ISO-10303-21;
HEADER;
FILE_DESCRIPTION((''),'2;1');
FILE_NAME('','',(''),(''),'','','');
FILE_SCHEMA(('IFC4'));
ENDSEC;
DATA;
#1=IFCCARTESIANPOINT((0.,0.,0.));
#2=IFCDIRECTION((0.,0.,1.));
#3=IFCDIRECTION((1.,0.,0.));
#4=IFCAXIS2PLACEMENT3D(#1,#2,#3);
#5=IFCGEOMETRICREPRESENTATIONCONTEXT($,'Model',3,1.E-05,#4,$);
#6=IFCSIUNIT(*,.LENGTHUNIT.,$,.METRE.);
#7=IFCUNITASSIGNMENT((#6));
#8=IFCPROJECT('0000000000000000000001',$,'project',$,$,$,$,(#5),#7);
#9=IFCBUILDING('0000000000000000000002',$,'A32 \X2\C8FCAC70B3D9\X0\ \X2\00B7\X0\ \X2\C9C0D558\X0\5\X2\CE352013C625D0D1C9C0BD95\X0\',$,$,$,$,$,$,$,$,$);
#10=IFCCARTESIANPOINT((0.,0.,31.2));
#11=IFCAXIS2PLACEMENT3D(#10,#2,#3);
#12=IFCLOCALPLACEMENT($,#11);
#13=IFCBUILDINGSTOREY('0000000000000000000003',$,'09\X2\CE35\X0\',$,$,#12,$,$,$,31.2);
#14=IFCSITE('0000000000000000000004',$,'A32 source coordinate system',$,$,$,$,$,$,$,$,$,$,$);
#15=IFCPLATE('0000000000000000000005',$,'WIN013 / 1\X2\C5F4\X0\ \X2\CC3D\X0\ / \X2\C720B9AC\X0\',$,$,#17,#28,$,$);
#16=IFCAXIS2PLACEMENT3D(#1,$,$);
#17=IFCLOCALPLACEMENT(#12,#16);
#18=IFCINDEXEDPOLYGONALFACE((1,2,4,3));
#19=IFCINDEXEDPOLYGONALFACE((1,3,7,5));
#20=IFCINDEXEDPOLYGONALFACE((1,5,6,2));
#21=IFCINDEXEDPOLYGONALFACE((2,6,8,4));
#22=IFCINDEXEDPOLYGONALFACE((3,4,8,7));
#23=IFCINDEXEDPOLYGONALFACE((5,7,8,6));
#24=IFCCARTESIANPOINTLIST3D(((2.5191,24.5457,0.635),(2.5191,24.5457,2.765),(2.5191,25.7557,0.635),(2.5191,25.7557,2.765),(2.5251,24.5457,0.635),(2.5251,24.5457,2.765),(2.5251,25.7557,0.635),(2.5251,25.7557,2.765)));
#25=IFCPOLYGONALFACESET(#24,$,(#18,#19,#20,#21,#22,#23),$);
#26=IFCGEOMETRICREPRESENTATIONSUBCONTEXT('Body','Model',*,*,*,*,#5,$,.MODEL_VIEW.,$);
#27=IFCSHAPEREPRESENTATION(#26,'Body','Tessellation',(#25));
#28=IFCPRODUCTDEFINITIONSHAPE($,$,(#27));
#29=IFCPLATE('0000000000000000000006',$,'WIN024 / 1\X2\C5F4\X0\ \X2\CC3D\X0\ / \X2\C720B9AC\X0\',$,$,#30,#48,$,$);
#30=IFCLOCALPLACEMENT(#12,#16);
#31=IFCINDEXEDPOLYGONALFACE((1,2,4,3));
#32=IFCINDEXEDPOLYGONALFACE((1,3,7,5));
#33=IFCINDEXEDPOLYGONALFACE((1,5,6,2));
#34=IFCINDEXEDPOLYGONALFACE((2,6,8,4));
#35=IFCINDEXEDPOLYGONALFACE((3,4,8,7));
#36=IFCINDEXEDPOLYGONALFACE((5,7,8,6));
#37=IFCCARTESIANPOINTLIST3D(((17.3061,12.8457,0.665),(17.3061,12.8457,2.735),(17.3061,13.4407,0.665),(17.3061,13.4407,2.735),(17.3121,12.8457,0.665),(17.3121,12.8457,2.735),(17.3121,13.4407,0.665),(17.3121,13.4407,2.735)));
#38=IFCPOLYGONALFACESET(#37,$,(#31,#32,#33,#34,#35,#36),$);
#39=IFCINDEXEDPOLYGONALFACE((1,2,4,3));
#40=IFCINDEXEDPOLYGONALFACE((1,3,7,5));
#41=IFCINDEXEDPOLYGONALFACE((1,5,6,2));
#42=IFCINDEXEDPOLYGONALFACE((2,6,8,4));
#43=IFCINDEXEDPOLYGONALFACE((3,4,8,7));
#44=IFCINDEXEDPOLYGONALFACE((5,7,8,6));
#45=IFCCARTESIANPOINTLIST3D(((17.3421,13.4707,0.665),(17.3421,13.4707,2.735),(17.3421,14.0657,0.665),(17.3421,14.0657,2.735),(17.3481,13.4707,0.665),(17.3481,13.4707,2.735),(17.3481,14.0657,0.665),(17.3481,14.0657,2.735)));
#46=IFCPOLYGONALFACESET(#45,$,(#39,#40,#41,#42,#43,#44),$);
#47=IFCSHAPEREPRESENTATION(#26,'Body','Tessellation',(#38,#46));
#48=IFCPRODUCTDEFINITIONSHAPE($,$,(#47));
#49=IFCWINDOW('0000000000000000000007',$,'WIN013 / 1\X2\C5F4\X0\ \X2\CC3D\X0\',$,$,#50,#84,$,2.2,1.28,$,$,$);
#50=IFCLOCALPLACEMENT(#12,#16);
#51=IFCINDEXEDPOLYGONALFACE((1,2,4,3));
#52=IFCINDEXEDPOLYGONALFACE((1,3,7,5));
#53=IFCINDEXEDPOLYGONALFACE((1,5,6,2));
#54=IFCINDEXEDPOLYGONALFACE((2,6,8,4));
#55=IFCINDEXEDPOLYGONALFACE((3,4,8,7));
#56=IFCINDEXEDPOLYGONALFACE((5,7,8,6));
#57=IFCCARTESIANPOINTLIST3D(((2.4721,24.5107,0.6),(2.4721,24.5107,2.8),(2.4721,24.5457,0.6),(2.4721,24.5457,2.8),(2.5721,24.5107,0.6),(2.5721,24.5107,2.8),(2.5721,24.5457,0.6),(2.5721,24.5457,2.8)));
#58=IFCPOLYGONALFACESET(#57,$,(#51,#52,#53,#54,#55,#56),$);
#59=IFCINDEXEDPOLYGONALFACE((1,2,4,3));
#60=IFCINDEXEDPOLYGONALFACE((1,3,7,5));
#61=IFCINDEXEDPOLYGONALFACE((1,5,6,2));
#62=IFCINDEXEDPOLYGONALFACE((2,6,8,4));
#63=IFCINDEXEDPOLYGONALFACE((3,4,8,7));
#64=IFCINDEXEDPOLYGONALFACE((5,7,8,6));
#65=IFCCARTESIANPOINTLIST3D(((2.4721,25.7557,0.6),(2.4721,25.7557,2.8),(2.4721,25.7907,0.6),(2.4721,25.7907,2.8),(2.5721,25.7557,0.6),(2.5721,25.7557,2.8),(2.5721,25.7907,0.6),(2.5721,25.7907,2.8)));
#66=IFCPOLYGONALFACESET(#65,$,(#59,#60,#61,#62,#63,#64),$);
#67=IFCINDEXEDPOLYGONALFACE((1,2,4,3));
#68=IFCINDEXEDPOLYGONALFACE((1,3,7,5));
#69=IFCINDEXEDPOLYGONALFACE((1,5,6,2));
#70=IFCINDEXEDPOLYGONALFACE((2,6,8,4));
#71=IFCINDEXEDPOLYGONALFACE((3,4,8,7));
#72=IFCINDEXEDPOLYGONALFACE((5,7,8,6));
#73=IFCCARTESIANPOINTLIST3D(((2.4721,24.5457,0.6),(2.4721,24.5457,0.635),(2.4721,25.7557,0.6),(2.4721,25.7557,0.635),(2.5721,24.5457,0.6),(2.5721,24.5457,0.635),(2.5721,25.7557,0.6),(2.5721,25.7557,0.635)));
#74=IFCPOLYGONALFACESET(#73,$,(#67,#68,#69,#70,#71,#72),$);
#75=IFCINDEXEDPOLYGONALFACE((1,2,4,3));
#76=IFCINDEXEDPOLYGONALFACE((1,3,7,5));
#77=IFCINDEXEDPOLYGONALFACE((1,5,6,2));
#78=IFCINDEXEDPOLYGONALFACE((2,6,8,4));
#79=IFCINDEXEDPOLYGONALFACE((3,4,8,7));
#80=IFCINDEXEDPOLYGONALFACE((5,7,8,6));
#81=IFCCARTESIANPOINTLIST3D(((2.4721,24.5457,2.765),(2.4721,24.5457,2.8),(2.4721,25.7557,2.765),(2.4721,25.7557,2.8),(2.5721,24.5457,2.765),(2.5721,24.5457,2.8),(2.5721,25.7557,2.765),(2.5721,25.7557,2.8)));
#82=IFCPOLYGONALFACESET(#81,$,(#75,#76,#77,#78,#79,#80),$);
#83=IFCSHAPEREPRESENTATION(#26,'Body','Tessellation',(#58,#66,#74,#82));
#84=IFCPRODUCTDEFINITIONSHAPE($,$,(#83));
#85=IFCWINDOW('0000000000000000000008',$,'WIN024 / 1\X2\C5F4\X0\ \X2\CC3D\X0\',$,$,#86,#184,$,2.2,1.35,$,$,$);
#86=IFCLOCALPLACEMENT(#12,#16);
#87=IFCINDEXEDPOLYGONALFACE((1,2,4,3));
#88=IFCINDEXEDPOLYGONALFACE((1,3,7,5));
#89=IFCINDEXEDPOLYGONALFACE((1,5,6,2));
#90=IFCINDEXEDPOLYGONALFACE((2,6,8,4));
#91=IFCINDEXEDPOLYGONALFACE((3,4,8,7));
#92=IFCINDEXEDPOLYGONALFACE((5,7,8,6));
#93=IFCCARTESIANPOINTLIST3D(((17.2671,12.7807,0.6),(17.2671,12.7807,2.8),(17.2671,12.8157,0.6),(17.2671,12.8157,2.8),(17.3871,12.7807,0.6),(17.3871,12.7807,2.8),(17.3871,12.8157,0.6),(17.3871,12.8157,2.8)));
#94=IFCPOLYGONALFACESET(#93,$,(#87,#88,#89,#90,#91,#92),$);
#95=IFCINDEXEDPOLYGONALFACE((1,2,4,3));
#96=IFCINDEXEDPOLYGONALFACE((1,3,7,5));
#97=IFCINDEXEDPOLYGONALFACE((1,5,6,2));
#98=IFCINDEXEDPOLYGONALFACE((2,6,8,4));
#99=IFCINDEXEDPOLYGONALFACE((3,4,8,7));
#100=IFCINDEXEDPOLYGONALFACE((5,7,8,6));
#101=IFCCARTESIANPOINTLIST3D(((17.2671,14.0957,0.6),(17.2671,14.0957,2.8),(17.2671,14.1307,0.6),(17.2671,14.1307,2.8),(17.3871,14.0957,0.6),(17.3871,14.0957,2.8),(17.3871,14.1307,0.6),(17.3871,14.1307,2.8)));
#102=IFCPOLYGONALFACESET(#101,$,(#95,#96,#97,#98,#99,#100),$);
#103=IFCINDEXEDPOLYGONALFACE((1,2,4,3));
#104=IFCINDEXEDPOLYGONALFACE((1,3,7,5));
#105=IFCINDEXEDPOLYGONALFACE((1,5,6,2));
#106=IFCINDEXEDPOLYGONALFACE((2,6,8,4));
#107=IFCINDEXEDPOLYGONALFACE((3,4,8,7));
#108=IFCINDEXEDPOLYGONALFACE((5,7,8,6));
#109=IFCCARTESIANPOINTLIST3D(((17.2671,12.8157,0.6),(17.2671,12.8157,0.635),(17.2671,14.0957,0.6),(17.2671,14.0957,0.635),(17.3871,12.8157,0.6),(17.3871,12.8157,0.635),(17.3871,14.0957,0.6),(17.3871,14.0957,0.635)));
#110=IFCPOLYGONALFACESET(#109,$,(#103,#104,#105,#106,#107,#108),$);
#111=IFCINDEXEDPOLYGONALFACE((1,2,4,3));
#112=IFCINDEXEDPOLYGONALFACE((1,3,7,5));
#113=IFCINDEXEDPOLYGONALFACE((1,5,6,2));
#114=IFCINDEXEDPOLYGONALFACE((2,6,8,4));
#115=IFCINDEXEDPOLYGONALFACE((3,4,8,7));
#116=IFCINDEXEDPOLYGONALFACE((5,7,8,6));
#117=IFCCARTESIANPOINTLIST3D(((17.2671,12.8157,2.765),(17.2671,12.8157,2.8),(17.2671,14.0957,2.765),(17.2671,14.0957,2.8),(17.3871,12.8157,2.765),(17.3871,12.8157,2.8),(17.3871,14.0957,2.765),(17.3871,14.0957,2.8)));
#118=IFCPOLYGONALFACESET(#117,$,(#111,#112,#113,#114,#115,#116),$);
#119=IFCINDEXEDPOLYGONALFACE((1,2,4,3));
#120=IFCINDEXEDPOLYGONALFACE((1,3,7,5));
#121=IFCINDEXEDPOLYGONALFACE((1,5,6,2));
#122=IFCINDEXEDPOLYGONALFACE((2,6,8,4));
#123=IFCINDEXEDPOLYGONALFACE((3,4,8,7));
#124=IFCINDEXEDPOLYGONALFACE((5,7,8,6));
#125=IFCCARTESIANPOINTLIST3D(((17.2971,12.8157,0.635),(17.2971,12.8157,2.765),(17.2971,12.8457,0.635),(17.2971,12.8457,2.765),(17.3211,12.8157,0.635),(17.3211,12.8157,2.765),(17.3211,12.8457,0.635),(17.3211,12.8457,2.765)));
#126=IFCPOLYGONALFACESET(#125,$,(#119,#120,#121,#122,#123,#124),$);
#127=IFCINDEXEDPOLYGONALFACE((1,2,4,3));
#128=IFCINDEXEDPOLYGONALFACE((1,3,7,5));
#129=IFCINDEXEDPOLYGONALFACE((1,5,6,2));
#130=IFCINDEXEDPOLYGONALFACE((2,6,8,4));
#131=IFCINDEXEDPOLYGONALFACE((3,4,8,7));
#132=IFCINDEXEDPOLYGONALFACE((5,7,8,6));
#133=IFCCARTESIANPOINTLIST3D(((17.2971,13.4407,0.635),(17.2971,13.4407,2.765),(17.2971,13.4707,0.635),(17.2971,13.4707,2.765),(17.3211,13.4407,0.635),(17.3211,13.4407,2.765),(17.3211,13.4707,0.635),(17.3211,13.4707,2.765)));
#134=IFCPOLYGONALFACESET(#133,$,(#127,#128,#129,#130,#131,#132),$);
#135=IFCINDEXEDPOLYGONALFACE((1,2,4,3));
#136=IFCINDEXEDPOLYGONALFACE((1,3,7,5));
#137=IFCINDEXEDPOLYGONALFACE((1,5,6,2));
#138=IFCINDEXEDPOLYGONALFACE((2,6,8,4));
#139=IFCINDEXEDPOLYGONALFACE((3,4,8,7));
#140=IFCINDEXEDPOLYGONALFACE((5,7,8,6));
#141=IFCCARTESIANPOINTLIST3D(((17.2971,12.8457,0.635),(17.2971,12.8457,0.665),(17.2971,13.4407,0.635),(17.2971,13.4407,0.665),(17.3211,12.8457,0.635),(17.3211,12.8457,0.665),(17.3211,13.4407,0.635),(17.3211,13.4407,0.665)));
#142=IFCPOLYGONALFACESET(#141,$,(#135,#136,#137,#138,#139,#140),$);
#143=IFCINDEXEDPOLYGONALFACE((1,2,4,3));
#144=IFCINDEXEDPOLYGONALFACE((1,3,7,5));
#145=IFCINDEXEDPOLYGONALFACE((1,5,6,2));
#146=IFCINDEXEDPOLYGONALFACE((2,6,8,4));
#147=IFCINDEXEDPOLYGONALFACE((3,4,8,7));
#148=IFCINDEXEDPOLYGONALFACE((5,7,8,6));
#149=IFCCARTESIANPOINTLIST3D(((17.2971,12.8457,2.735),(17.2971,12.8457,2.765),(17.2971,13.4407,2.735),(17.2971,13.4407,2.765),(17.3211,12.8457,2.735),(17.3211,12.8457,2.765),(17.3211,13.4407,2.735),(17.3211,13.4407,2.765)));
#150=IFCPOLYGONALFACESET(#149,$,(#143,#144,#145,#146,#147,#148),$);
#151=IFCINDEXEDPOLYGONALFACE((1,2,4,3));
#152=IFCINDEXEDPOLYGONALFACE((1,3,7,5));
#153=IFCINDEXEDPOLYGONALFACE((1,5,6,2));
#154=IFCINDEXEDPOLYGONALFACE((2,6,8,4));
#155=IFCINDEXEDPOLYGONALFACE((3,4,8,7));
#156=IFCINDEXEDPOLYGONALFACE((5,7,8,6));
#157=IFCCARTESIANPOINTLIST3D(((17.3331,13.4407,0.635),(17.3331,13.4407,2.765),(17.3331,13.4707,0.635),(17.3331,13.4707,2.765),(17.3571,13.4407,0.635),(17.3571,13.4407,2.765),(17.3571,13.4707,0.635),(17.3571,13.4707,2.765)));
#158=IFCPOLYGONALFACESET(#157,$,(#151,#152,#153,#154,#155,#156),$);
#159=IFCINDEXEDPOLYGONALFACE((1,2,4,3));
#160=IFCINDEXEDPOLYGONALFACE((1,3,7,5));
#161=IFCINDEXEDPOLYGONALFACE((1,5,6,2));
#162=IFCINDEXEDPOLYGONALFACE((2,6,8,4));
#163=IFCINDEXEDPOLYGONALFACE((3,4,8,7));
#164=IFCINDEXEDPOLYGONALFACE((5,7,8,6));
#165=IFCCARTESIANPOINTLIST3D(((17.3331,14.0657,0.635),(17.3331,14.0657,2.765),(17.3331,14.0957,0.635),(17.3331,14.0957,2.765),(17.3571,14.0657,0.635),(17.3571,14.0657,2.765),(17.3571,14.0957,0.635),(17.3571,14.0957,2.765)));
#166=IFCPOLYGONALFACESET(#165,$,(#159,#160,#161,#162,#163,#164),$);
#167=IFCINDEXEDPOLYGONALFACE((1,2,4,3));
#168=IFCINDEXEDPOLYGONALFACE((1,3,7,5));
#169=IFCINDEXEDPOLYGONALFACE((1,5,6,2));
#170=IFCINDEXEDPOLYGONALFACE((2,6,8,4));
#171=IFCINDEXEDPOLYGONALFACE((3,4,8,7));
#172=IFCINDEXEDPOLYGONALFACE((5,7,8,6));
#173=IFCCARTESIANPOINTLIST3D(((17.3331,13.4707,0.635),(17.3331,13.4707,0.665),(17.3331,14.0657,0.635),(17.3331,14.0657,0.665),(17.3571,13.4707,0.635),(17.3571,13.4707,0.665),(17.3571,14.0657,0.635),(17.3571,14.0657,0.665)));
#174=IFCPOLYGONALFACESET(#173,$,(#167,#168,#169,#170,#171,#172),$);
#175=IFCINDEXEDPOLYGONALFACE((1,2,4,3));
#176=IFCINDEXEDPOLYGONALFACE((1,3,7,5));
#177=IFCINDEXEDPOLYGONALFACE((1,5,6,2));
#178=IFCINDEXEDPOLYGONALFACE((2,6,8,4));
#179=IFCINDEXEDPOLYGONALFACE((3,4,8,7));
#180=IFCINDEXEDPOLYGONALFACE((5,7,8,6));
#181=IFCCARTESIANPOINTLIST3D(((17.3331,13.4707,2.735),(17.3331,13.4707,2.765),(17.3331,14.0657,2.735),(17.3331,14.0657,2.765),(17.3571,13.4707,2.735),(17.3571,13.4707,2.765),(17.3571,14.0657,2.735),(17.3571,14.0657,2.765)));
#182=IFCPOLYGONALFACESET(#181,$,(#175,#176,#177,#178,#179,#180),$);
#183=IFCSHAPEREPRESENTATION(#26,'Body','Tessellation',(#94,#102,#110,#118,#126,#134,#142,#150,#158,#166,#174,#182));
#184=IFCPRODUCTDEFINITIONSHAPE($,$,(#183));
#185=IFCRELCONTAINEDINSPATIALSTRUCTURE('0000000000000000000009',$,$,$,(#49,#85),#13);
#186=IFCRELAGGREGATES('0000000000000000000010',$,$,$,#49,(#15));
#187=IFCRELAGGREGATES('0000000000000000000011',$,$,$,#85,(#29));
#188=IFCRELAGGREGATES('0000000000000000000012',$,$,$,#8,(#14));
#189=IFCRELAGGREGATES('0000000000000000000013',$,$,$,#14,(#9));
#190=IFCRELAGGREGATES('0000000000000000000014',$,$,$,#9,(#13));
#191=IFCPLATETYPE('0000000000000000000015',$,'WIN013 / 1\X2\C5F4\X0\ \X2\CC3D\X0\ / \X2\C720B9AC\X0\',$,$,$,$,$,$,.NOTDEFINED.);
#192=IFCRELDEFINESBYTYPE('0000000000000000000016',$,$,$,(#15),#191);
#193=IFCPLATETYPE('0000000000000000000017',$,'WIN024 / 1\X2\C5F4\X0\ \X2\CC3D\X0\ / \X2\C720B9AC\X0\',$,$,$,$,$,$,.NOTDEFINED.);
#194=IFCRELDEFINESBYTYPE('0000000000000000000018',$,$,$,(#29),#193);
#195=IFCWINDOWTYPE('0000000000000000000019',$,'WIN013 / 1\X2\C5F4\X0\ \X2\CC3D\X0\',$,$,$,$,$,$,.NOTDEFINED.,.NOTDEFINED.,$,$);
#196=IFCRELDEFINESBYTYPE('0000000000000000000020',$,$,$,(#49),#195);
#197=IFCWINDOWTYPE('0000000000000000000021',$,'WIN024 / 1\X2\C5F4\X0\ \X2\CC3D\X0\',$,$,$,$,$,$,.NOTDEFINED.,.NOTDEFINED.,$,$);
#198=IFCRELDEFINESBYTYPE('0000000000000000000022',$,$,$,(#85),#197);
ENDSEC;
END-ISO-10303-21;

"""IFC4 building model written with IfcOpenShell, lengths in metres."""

from ifc_helpers import new_model, si_unit, frame, origin, origin_with_axes, place, context, subcontext, project, spatial, polyline, outline, extrude, source, transform, mapped, type_object, type_shapes, element, aggregate, save


model = new_model("IFC4")

# Units and contexts
model_context = context("Model", 3, precision=1e-05, world=origin_with_axes())
body_context = subcontext(model_context, "Body", "Model", "MODEL_VIEW")
ifc_project = project(units=[si_unit("LENGTHUNIT", "METRE")], contexts=[model_context])

# Plates
plate_type_1 = type_object("IfcPlateType", Name="WIN013 / 1열 창 / 유리", PredefinedType="NOTDEFINED")
shared_shape_1 = source(origin(), body_context, "Body", "SweptSolid", [
    extrude(outline(polyline([(2.5191, 24.5457), (2.5191, 25.7557), (2.5251, 25.7557), (2.5251, 24.5457), (2.5191, 24.5457)])), frame((0.0, 0.0, 0.635)), (0.0, 0.0, 1.0), 2.13),
])
type_shapes(plate_type_1, [shared_shape_1])
storey_placement = place(None, frame((0.0, 0.0, 31.2), z_axis=(0.0, 0.0, 1.0), x_axis=(1.0, 0.0, 0.0)))
window_1_placement = place(storey_placement, origin_with_axes())
plate_1_placement = place(window_1_placement, origin_with_axes())
plate_1 = element("IfcPlate", 1, at=plate_1_placement, type_object=plate_type_1, Name="WIN013 / 1열 창 / 유리", context=body_context, shape_type="MappedRepresentation", body=[
    mapped(shared_shape_1, transform((0.0, 0.0, 0.0), scale=1.0)),
])
plate_type_2 = type_object("IfcPlateType", Name="WIN024 / 1열 창 / 유리", PredefinedType="NOTDEFINED")
shared_shape_2 = source(origin(), body_context, "Body", "SweptSolid", [
    extrude(outline(polyline([(17.3061, 12.8457), (17.3061, 13.4407), (17.3121, 13.4407), (17.3121, 12.8457), (17.3061, 12.8457)])), frame((0.0, 0.0, 0.665)), (0.0, 0.0, 1.0), 2.07),
    extrude(outline(polyline([(17.3421, 13.4707), (17.3421, 14.0657), (17.3481, 14.0657), (17.3481, 13.4707), (17.3421, 13.4707)])), frame((0.0, 0.0, 0.665)), (0.0, 0.0, 1.0), 2.07),
])
type_shapes(plate_type_2, [shared_shape_2])
window_2_placement = place(storey_placement, origin_with_axes())
plate_2_placement = place(window_2_placement, origin_with_axes())
plate_2 = element("IfcPlate", 2, at=plate_2_placement, type_object=plate_type_2, Name="WIN024 / 1열 창 / 유리", context=body_context, shape_type="MappedRepresentation", body=[
    mapped(shared_shape_2, transform((0.0, 0.0, 0.0), scale=1.0)),
])

# Site, building, storey
site = spatial("IfcSite", under=ifc_project, Name="A32 source coordinate system")
building = spatial("IfcBuilding", under=site, Name="A32 주거동 · 지하5층–옥탑지붕")
storey = spatial("IfcBuildingStorey", under=building, at=storey_placement, Name="09층", Elevation=31.2)

# Windows
window_type_1 = type_object("IfcWindowType", Name="WIN013 / 1열 창", PartitioningType="NOTDEFINED", PredefinedType="NOTDEFINED")
shared_shape_3 = source(origin(), body_context, "Body", "SweptSolid", [
    extrude(outline(polyline([(2.4721, 24.5107), (2.4721, 24.5457), (2.5721, 24.5457), (2.5721, 24.5107), (2.4721, 24.5107)])), frame((0.0, 0.0, 0.6)), (0.0, 0.0, 1.0), 2.2),
    extrude(outline(polyline([(2.4721, 25.7557), (2.4721, 25.7907), (2.5721, 25.7907), (2.5721, 25.7557), (2.4721, 25.7557)])), frame((0.0, 0.0, 0.6)), (0.0, 0.0, 1.0), 2.2),
    extrude(outline(polyline([(2.4721, 24.5457), (2.4721, 25.7557), (2.5721, 25.7557), (2.5721, 24.5457), (2.4721, 24.5457)])), frame((0.0, 0.0, 0.6)), (0.0, 0.0, 1.0), 0.035),
    extrude(outline(polyline([(2.4721, 24.5457), (2.4721, 25.7557), (2.5721, 25.7557), (2.5721, 24.5457), (2.4721, 24.5457)])), frame((0.0, 0.0, 2.765)), (0.0, 0.0, 1.0), 0.035),
])
type_shapes(window_type_1, [shared_shape_3])
window_1 = element("IfcWindow", 3, at=window_1_placement, inside=storey, type_object=window_type_1, Name="WIN013 / 1열 창", OverallHeight=2.2, OverallWidth=1.28, context=body_context, shape_type="MappedRepresentation", body=[
    mapped(shared_shape_3, transform((0.0, 0.0, 0.0), scale=1.0)),
])
aggregate(window_1, [plate_1])
window_type_2 = type_object("IfcWindowType", Name="WIN024 / 1열 창", PartitioningType="NOTDEFINED", PredefinedType="NOTDEFINED")
shared_shape_4 = source(origin(), body_context, "Body", "SweptSolid", [
    extrude(outline(polyline([(17.2671, 12.7807), (17.2671, 12.8157), (17.3871, 12.8157), (17.3871, 12.7807), (17.2671, 12.7807)])), frame((0.0, 0.0, 0.6)), (0.0, 0.0, 1.0), 2.2),
    extrude(outline(polyline([(17.2671, 14.0957), (17.2671, 14.1307), (17.3871, 14.1307), (17.3871, 14.0957), (17.2671, 14.0957)])), frame((0.0, 0.0, 0.6)), (0.0, 0.0, 1.0), 2.2),
    extrude(outline(polyline([(17.2671, 12.8157), (17.2671, 14.0957), (17.3871, 14.0957), (17.3871, 12.8157), (17.2671, 12.8157)])), frame((0.0, 0.0, 0.6)), (0.0, 0.0, 1.0), 0.035),
    extrude(outline(polyline([(17.2671, 12.8157), (17.2671, 14.0957), (17.3871, 14.0957), (17.3871, 12.8157), (17.2671, 12.8157)])), frame((0.0, 0.0, 2.765)), (0.0, 0.0, 1.0), 0.035),
    extrude(outline(polyline([(17.2971, 12.8157), (17.2971, 12.8457), (17.3211, 12.8457), (17.3211, 12.8157), (17.2971, 12.8157)])), frame((0.0, 0.0, 0.635)), (0.0, 0.0, 1.0), 2.13),
    extrude(outline(polyline([(17.2971, 13.4407), (17.2971, 13.4707), (17.3211, 13.4707), (17.3211, 13.4407), (17.2971, 13.4407)])), frame((0.0, 0.0, 0.635)), (0.0, 0.0, 1.0), 2.13),
    extrude(outline(polyline([(17.2971, 12.8457), (17.2971, 13.4407), (17.3211, 13.4407), (17.3211, 12.8457), (17.2971, 12.8457)])), frame((0.0, 0.0, 0.635)), (0.0, 0.0, 1.0), 0.03),
    extrude(outline(polyline([(17.2971, 12.8457), (17.2971, 13.4407), (17.3211, 13.4407), (17.3211, 12.8457), (17.2971, 12.8457)])), frame((0.0, 0.0, 2.735)), (0.0, 0.0, 1.0), 0.03),
    extrude(outline(polyline([(17.3331, 13.4407), (17.3331, 13.4707), (17.3571, 13.4707), (17.3571, 13.4407), (17.3331, 13.4407)])), frame((0.0, 0.0, 0.635)), (0.0, 0.0, 1.0), 2.13),
    extrude(outline(polyline([(17.3331, 14.0657), (17.3331, 14.0957), (17.3571, 14.0957), (17.3571, 14.0657), (17.3331, 14.0657)])), frame((0.0, 0.0, 0.635)), (0.0, 0.0, 1.0), 2.13),
    extrude(outline(polyline([(17.3331, 13.4707), (17.3331, 14.0657), (17.3571, 14.0657), (17.3571, 13.4707), (17.3331, 13.4707)])), frame((0.0, 0.0, 0.635)), (0.0, 0.0, 1.0), 0.03),
    extrude(outline(polyline([(17.3331, 13.4707), (17.3331, 14.0657), (17.3571, 14.0657), (17.3571, 13.4707), (17.3331, 13.4707)])), frame((0.0, 0.0, 2.735)), (0.0, 0.0, 1.0), 0.03),
])
type_shapes(window_type_2, [shared_shape_4])
window_2 = element("IfcWindow", 4, at=window_2_placement, inside=storey, type_object=window_type_2, Name="WIN024 / 1열 창", OverallHeight=2.2, OverallWidth=1.35, context=body_context, shape_type="MappedRepresentation", body=[
    mapped(shared_shape_4, transform((0.0, 0.0, 0.0), scale=1.0)),
])
aggregate(window_2, [plate_2])

save(model, "model.ifc")
